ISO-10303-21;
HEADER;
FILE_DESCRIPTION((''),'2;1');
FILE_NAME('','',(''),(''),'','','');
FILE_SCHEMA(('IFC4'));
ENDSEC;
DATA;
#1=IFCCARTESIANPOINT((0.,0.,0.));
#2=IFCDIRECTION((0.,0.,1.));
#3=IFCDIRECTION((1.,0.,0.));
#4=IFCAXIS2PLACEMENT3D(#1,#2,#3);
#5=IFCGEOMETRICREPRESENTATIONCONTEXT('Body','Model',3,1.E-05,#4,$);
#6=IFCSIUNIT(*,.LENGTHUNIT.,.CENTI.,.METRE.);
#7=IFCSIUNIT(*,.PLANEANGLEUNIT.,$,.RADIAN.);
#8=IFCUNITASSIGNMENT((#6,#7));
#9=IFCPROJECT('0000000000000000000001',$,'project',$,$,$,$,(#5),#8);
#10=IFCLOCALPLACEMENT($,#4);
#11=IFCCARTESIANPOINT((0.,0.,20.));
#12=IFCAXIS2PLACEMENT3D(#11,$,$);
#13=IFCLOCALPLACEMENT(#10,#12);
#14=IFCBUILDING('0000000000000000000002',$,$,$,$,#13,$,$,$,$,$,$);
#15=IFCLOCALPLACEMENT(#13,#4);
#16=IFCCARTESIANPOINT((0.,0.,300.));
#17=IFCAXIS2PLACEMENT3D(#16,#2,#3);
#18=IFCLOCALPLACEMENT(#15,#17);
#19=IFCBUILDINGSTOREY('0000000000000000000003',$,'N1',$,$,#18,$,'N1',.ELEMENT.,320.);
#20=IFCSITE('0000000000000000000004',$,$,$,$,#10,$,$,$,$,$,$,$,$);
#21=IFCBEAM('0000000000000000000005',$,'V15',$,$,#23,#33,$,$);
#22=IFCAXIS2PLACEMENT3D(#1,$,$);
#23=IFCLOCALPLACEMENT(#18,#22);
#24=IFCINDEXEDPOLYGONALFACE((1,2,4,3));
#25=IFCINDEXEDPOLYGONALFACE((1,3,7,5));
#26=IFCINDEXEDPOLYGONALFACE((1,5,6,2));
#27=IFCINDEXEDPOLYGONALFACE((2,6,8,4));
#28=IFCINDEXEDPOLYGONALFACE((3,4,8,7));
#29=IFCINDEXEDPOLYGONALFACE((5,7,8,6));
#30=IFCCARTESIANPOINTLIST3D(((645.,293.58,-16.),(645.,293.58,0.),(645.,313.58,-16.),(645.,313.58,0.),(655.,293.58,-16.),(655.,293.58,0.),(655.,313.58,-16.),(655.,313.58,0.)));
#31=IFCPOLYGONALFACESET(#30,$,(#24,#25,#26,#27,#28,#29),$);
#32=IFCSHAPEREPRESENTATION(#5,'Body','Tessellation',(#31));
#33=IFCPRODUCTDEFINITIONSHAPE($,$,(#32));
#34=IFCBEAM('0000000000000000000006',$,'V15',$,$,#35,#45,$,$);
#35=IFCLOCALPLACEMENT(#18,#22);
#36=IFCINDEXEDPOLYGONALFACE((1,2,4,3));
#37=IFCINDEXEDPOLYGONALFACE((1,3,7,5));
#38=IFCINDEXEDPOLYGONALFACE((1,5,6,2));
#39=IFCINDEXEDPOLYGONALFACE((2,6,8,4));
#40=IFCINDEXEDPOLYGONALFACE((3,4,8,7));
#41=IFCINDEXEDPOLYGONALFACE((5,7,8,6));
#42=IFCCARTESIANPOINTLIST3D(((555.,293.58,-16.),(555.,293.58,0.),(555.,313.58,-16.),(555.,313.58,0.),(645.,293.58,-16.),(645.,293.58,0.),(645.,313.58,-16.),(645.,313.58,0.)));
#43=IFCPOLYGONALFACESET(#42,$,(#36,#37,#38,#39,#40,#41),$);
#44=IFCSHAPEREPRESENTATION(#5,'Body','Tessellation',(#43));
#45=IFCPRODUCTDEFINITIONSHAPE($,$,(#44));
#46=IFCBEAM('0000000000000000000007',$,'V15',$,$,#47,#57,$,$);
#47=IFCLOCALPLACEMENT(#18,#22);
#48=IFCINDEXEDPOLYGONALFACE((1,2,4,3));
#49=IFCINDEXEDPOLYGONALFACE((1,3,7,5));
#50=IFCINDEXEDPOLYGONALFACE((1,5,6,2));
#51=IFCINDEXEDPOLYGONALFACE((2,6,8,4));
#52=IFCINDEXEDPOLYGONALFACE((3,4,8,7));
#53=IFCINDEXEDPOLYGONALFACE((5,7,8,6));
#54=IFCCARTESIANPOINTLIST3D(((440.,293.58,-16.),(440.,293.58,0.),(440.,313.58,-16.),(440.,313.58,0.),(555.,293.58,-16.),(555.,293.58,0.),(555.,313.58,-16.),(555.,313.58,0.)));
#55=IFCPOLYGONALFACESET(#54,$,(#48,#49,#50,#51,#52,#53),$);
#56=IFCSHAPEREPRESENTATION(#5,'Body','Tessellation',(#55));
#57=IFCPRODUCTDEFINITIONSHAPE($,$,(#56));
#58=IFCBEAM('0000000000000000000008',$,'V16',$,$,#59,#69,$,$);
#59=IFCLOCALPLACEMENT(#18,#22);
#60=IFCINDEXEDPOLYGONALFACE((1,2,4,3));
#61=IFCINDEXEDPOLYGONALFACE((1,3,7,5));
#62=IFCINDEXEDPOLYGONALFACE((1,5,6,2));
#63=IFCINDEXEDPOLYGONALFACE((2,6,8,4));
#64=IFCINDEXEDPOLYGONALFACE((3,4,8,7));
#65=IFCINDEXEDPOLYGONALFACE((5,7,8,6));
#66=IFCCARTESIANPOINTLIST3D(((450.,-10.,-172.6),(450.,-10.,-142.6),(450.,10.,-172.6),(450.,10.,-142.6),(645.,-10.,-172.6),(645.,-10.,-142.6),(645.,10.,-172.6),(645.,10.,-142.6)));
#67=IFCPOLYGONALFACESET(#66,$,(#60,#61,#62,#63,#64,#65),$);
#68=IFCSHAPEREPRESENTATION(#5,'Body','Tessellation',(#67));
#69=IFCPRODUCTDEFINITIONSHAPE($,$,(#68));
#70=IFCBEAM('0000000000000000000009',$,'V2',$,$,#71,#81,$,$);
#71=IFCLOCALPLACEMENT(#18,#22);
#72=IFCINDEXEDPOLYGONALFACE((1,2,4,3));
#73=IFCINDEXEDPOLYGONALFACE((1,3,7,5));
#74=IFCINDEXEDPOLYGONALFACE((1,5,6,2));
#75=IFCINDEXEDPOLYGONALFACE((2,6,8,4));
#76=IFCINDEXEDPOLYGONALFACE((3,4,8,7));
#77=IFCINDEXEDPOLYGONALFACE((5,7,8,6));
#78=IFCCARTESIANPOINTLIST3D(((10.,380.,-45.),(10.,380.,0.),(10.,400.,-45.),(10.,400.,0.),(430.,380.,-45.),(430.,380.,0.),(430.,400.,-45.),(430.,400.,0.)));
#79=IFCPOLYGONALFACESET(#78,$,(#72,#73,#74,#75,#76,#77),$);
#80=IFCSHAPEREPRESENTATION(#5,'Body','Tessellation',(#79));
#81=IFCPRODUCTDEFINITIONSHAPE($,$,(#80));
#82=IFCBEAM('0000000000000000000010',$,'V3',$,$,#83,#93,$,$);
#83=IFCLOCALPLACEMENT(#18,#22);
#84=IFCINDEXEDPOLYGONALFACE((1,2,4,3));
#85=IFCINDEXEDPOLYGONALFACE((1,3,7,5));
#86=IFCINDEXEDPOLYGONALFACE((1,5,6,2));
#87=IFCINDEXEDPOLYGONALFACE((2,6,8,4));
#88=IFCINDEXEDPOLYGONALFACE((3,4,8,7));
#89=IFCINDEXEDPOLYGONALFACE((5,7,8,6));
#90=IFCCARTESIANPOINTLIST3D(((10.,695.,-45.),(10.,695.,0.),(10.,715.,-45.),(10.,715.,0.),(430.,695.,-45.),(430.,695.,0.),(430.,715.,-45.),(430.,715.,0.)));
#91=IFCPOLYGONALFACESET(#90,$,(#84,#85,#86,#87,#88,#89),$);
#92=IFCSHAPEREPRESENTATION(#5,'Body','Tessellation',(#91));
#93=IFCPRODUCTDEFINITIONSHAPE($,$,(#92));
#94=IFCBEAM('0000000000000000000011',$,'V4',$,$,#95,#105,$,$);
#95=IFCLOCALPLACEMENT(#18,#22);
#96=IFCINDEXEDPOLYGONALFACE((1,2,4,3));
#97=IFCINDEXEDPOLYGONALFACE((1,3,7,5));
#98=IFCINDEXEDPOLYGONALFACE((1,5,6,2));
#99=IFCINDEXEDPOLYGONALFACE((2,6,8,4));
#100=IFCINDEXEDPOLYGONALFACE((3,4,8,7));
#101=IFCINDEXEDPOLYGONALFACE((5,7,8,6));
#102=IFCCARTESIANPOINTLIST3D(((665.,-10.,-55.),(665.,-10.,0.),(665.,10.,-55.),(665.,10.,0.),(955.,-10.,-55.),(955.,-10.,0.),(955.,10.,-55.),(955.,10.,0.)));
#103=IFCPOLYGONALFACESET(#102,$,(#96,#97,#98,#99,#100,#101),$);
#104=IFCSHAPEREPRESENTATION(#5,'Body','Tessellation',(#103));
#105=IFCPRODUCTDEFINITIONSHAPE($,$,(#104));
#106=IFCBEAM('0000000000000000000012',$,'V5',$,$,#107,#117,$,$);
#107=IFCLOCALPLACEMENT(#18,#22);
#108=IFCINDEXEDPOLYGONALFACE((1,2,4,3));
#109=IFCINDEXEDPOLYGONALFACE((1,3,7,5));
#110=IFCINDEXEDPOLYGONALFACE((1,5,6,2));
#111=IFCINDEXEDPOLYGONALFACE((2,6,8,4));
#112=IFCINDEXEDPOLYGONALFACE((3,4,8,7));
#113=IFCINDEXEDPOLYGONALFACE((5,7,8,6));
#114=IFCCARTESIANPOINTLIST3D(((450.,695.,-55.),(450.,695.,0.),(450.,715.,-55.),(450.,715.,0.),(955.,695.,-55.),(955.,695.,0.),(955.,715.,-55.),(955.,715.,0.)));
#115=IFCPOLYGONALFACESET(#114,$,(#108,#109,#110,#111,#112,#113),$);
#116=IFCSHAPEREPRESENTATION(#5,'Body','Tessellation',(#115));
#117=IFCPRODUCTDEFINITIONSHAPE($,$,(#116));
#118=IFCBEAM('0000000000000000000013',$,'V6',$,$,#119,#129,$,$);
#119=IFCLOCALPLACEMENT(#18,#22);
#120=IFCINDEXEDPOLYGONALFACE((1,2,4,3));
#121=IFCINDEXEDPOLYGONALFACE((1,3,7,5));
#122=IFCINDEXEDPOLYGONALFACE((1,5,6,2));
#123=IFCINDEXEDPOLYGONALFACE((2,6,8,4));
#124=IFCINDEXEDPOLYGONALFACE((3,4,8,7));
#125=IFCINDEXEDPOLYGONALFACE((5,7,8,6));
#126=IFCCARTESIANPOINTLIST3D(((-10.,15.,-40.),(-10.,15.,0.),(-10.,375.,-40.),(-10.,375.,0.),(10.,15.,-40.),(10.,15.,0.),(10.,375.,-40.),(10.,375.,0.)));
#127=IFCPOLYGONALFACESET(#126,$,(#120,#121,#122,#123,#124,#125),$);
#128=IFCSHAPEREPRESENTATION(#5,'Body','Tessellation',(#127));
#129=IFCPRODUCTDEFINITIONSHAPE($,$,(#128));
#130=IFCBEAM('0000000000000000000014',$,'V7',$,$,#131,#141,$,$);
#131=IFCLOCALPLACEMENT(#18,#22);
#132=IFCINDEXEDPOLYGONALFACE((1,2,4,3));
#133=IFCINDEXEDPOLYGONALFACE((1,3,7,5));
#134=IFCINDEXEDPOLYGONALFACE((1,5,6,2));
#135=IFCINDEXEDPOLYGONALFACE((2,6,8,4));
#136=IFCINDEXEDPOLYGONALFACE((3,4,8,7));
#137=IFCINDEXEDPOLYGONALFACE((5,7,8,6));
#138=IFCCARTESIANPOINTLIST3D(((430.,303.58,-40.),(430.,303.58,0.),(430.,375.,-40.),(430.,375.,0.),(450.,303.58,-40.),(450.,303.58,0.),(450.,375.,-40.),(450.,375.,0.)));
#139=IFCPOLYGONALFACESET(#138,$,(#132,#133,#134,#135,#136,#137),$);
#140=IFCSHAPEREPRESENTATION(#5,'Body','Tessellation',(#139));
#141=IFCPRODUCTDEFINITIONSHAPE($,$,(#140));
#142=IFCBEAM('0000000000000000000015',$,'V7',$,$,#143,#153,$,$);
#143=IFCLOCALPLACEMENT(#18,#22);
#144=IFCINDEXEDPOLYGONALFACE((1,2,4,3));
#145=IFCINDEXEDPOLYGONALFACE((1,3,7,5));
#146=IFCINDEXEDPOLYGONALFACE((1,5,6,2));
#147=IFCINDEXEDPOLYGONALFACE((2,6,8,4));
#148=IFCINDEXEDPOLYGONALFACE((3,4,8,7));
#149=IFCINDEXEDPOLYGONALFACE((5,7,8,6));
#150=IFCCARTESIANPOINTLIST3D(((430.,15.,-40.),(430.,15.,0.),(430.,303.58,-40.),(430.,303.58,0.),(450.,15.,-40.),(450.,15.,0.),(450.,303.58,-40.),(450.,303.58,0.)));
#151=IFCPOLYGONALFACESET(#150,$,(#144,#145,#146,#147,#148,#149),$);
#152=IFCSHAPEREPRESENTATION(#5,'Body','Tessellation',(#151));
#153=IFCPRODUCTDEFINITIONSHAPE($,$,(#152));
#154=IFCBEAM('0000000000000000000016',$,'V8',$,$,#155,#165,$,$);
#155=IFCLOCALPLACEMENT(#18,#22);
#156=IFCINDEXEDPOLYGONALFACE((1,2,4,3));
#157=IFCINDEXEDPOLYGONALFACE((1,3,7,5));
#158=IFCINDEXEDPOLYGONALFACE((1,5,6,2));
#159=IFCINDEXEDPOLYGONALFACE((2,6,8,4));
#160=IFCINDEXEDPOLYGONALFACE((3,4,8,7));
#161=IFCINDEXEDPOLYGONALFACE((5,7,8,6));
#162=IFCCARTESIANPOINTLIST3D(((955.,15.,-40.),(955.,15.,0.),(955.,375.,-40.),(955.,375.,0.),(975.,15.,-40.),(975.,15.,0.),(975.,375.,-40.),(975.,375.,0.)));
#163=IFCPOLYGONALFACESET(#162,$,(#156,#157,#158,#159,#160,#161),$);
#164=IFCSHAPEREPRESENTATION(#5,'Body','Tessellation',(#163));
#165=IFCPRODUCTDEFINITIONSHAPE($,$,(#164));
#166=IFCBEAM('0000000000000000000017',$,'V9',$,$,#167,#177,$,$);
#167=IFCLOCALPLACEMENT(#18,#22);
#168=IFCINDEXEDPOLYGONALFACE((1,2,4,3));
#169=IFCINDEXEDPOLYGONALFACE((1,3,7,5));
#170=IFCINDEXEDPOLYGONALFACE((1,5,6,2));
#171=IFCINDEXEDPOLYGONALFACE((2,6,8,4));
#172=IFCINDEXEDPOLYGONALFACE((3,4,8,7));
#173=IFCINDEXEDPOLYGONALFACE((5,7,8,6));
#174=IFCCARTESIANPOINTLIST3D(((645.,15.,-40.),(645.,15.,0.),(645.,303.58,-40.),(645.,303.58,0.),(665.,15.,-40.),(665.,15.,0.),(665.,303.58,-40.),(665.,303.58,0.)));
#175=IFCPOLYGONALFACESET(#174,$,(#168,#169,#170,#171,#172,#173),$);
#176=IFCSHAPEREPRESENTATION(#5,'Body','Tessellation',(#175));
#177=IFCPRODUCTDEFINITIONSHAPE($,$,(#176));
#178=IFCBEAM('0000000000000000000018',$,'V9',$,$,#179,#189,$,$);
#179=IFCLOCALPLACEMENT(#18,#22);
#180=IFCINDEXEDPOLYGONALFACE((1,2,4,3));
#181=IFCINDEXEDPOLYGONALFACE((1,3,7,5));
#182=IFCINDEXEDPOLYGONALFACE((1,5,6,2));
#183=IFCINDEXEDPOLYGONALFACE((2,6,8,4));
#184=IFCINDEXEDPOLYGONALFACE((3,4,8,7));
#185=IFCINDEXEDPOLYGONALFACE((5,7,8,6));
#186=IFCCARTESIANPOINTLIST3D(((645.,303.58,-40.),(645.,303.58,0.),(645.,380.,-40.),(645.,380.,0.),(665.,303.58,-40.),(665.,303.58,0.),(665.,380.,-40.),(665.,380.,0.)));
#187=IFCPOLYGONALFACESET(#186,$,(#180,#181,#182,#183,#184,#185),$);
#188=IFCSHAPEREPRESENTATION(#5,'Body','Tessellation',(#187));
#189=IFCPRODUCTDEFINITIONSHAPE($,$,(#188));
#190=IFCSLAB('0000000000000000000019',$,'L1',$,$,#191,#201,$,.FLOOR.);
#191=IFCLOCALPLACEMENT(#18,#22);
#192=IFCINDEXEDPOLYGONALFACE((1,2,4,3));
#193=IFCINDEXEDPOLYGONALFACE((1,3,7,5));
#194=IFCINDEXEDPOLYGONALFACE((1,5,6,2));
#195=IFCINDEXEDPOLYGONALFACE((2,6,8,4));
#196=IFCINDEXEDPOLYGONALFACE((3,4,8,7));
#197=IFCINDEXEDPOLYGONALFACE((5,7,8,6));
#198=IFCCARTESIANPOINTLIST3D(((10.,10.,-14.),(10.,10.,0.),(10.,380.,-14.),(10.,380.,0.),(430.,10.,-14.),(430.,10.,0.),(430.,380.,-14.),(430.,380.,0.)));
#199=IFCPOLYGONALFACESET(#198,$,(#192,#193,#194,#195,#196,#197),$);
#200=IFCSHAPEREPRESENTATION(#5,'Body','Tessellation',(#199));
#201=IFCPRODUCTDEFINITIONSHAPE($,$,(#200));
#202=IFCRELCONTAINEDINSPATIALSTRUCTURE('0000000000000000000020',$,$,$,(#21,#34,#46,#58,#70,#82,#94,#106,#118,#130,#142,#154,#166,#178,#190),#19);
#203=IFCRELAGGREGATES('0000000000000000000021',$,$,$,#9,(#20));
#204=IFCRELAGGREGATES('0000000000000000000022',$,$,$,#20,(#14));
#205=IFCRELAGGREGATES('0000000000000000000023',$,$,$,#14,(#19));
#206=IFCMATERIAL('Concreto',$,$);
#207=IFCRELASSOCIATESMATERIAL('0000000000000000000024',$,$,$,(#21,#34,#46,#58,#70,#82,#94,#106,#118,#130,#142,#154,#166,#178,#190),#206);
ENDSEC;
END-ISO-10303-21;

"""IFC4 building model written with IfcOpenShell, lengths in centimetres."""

from ifc_helpers import new_model, si_unit, frame, origin_with_axes, origin_2d_with_axis, place, context, project, spatial, polyline, rectangle, outline, extrude, material, element, save


model = new_model("IFC4")

# Units and contexts
model_context = context("Model", 3, precision=1e-05, world=origin_with_axes(), identifier="Body")
ifc_project = project(units=[si_unit("LENGTHUNIT", "METRE", prefix="CENTI"), si_unit("PLANEANGLEUNIT", "RADIAN")], contexts=[model_context])

# Site, building, storey
site_placement = place(None, origin_with_axes())
site = spatial("IfcSite", under=ifc_project, at=site_placement)
building_placement = place(site_placement, frame((0.0, 0.0, 20.0)))
building = spatial("IfcBuilding", under=site, at=building_placement)
placement = place(building_placement, origin_with_axes())
storey_placement = place(placement, frame((0.0, 0.0, 300.0), z_axis=(0.0, 0.0, 1.0), x_axis=(1.0, 0.0, 0.0)))
storey = spatial("IfcBuildingStorey", under=building, at=storey_placement, Name="N1", LongName="N1", CompositionType="ELEMENT", Elevation=320.0)

# Shared definitions
ifc_material = material(Name="Concreto")

# Beams
beam_1_placement = place(storey_placement, frame((650.0, 303.58, 0.0), z_axis=(0.0, 0.0, 1.0), x_axis=(1.0, 0.0, 0.0)))
element("IfcBeam", 1, at=beam_1_placement, inside=storey, material=ifc_material, Name="V15", context=model_context, shape_type="SolidModel", body=[
    extrude(rectangle(XDim=20.0, YDim=16.0, at=origin_2d_with_axis()), frame((-5.0, 0.0, -8.0), z_axis=(1.0, 0.0, 0.0), x_axis=(0.0, 1.0, 0.0)), (0.0, 0.0, 1.0), 10.0),
])
beam_2_placement = place(storey_placement, frame((600.0, 303.58, 0.0), z_axis=(0.0, 0.0, 1.0), x_axis=(1.0, 0.0, 0.0)))
element("IfcBeam", 2, at=beam_2_placement, inside=storey, material=ifc_material, Name="V15", context=model_context, shape_type="SolidModel", body=[
    extrude(rectangle(XDim=20.0, YDim=16.0, at=origin_2d_with_axis()), frame((-45.0, 0.0, -8.0), z_axis=(1.0, 0.0, 0.0), x_axis=(0.0, 1.0, 0.0)), (0.0, 0.0, 1.0), 90.0),
])
beam_3_placement = place(storey_placement, frame((497.5, 303.58, 0.0), z_axis=(0.0, 0.0, 1.0), x_axis=(1.0, 0.0, 0.0)))
element("IfcBeam", 3, at=beam_3_placement, inside=storey, material=ifc_material, Name="V15", context=model_context, shape_type="SolidModel", body=[
    extrude(rectangle(XDim=20.0, YDim=16.0, at=origin_2d_with_axis()), frame((-57.5, 0.0, -8.0), z_axis=(1.0, 0.0, 0.0), x_axis=(0.0, 1.0, 0.0)), (0.0, 0.0, 1.0), 115.0),
])
beam_4_placement = place(storey_placement, frame((547.5, 0.0, -142.6), z_axis=(0.0, 0.0, 1.0), x_axis=(1.0, 0.0, 0.0)))
element("IfcBeam", 4, at=beam_4_placement, inside=storey, material=ifc_material, Name="V16", context=model_context, shape_type="SolidModel", body=[
    extrude(rectangle(XDim=20.0, YDim=30.0, at=origin_2d_with_axis()), frame((-97.5, 0.0, -15.0), z_axis=(1.0, 0.0, 0.0), x_axis=(0.0, 1.0, 0.0)), (0.0, 0.0, 1.0), 195.0),
])
for number, where, z_axis, x_axis, name in (
    (5, (220.0, 390.0, 0.0), (0.0, 0.0, 1.0), (1.0, 0.0, 0.0), "V2"),
    (6, (220.0, 705.0, 0.0), (0.0, 0.0, 1.0), (1.0, 0.0, 0.0), "V3"),
):
    element("IfcBeam", number, at=place(storey_placement, frame(where, z_axis=z_axis, x_axis=x_axis)), inside=storey, material=ifc_material, Name=name, context=model_context, shape_type="SolidModel", body=[
        extrude(rectangle(XDim=20.0, YDim=45.0, at=origin_2d_with_axis()), frame((-210.0, 0.0, -22.5), z_axis=(1.0, 0.0, 0.0), x_axis=(0.0, 1.0, 0.0)), (0.0, 0.0, 1.0), 420.0),
    ])
beam_5_placement = place(storey_placement, frame((810.0, 0.0, 0.0), z_axis=(0.0, 0.0, 1.0), x_axis=(1.0, 0.0, 0.0)))
element("IfcBeam", 7, at=beam_5_placement, inside=storey, material=ifc_material, Name="V4", context=model_context, shape_type="SolidModel", body=[
    extrude(rectangle(XDim=20.0, YDim=55.0, at=origin_2d_with_axis()), frame((-145.0, 0.0, -27.5), z_axis=(1.0, 0.0, 0.0), x_axis=(0.0, 1.0, 0.0)), (0.0, 0.0, 1.0), 290.0),
])
beam_6_placement = place(storey_placement, frame((702.5, 705.0, 0.0), z_axis=(0.0, 0.0, 1.0), x_axis=(1.0, 0.0, 0.0)))
element("IfcBeam", 8, at=beam_6_placement, inside=storey, material=ifc_material, Name="V5", context=model_context, shape_type="SolidModel", body=[
    extrude(rectangle(XDim=20.0, YDim=55.0, at=origin_2d_with_axis()), frame((-252.5, 0.0, -27.5), z_axis=(1.0, 0.0, 0.0), x_axis=(0.0, 1.0, 0.0)), (0.0, 0.0, 1.0), 505.0),
])
beam_7_placement = place(storey_placement, frame((0.0, 195.0, 0.0), z_axis=(0.0, 0.0, 1.0), x_axis=(1.0, 0.0, 0.0)))
element("IfcBeam", 9, at=beam_7_placement, inside=storey, material=ifc_material, Name="V6", context=model_context, shape_type="SolidModel", body=[
    extrude(rectangle(XDim=20.0, YDim=40.0, at=origin_2d_with_axis()), frame((0.0, -180.0, -20.0), z_axis=(0.0, 1.0, 0.0), x_axis=(-1.0, 0.0, 0.0)), (0.0, 0.0, 1.0), 360.0),
])
beam_8_placement = place(storey_placement, frame((440.0, 339.29, 0.0), z_axis=(0.0, 0.0, 1.0), x_axis=(1.0, 0.0, 0.0)))
element("IfcBeam", 10, at=beam_8_placement, inside=storey, material=ifc_material, Name="V7", context=model_context, shape_type="SolidModel", body=[
    extrude(rectangle(XDim=20.0, YDim=40.0, at=origin_2d_with_axis()), frame((0.0, -35.71, -20.0), z_axis=(0.0, 1.0, 0.0), x_axis=(1.0, 0.0, 0.0)), (0.0, 0.0, 1.0), 71.42),
])
beam_9_placement = place(storey_placement, frame((440.0, 159.29, 0.0), z_axis=(0.0, 0.0, 1.0), x_axis=(1.0, 0.0, 0.0)))
element("IfcBeam", 11, at=beam_9_placement, inside=storey, material=ifc_material, Name="V7", context=model_context, shape_type="SolidModel", body=[
    extrude(rectangle(XDim=20.0, YDim=40.0, at=origin_2d_with_axis()), frame((0.0, -144.29, -20.0), z_axis=(0.0, 1.0, 0.0), x_axis=(1.0, 0.0, 0.0)), (0.0, 0.0, 1.0), 288.58),
])
beam_10_placement = place(storey_placement, frame((965.0, 195.0, 0.0), z_axis=(0.0, 0.0, 1.0), x_axis=(1.0, 0.0, 0.0)))
element("IfcBeam", 12, at=beam_10_placement, inside=storey, material=ifc_material, Name="V8", context=model_context, shape_type="SolidModel", body=[
    extrude(rectangle(XDim=20.0, YDim=40.0, at=origin_2d_with_axis()), frame((0.0, -180.0, -20.0), z_axis=(0.0, 1.0, 0.0), x_axis=(1.0, 0.0, 0.0)), (0.0, 0.0, 1.0), 360.0),
])
beam_11_placement = place(storey_placement, frame((655.0, 159.29, 0.0), z_axis=(0.0, 0.0, 1.0), x_axis=(1.0, 0.0, 0.0)))
element("IfcBeam", 13, at=beam_11_placement, inside=storey, material=ifc_material, Name="V9", context=model_context, shape_type="SolidModel", body=[
    extrude(rectangle(XDim=20.0, YDim=40.0, at=origin_2d_with_axis()), frame((0.0, -144.29, -20.0), z_axis=(0.0, 1.0, 0.0), x_axis=(1.0, 0.0, 0.0)), (0.0, 0.0, 1.0), 288.58),
])
beam_12_placement = place(storey_placement, frame((655.0, 341.79, 0.0), z_axis=(0.0, 0.0, 1.0), x_axis=(1.0, 0.0, 0.0)))
element("IfcBeam", 14, at=beam_12_placement, inside=storey, material=ifc_material, Name="V9", context=model_context, shape_type="SolidModel", body=[
    extrude(rectangle(XDim=20.0, YDim=40.0, at=origin_2d_with_axis()), frame((0.0, -38.21, -20.0), z_axis=(0.0, 1.0, 0.0), x_axis=(1.0, 0.0, 0.0)), (0.0, 0.0, 1.0), 76.42),
])

# Slab
slab_1_placement = place(storey_placement, frame((220.0, 195.0, 0.0), z_axis=(0.0, 0.0, 1.0), x_axis=(1.0, 0.0, 0.0)))
element("IfcSlab", 15, at=slab_1_placement, inside=storey, material=ifc_material, Name="L1", PredefinedType="FLOOR", context=model_context, shape_type="SolidModel", body=[
    extrude(outline(polyline([(210.0, 185.0), (-210.0, 185.0), (-210.0, -185.0), (210.0, -185.0), (210.0, 185.0), (210.0, 185.0)])), frame((0.0, 0.0, -14.0), z_axis=(0.0, 0.0, 1.0), x_axis=(1.0, 0.0, 0.0)), (0.0, 0.0, 1.0), 14.0),
])

save(model, "model.ifc")
